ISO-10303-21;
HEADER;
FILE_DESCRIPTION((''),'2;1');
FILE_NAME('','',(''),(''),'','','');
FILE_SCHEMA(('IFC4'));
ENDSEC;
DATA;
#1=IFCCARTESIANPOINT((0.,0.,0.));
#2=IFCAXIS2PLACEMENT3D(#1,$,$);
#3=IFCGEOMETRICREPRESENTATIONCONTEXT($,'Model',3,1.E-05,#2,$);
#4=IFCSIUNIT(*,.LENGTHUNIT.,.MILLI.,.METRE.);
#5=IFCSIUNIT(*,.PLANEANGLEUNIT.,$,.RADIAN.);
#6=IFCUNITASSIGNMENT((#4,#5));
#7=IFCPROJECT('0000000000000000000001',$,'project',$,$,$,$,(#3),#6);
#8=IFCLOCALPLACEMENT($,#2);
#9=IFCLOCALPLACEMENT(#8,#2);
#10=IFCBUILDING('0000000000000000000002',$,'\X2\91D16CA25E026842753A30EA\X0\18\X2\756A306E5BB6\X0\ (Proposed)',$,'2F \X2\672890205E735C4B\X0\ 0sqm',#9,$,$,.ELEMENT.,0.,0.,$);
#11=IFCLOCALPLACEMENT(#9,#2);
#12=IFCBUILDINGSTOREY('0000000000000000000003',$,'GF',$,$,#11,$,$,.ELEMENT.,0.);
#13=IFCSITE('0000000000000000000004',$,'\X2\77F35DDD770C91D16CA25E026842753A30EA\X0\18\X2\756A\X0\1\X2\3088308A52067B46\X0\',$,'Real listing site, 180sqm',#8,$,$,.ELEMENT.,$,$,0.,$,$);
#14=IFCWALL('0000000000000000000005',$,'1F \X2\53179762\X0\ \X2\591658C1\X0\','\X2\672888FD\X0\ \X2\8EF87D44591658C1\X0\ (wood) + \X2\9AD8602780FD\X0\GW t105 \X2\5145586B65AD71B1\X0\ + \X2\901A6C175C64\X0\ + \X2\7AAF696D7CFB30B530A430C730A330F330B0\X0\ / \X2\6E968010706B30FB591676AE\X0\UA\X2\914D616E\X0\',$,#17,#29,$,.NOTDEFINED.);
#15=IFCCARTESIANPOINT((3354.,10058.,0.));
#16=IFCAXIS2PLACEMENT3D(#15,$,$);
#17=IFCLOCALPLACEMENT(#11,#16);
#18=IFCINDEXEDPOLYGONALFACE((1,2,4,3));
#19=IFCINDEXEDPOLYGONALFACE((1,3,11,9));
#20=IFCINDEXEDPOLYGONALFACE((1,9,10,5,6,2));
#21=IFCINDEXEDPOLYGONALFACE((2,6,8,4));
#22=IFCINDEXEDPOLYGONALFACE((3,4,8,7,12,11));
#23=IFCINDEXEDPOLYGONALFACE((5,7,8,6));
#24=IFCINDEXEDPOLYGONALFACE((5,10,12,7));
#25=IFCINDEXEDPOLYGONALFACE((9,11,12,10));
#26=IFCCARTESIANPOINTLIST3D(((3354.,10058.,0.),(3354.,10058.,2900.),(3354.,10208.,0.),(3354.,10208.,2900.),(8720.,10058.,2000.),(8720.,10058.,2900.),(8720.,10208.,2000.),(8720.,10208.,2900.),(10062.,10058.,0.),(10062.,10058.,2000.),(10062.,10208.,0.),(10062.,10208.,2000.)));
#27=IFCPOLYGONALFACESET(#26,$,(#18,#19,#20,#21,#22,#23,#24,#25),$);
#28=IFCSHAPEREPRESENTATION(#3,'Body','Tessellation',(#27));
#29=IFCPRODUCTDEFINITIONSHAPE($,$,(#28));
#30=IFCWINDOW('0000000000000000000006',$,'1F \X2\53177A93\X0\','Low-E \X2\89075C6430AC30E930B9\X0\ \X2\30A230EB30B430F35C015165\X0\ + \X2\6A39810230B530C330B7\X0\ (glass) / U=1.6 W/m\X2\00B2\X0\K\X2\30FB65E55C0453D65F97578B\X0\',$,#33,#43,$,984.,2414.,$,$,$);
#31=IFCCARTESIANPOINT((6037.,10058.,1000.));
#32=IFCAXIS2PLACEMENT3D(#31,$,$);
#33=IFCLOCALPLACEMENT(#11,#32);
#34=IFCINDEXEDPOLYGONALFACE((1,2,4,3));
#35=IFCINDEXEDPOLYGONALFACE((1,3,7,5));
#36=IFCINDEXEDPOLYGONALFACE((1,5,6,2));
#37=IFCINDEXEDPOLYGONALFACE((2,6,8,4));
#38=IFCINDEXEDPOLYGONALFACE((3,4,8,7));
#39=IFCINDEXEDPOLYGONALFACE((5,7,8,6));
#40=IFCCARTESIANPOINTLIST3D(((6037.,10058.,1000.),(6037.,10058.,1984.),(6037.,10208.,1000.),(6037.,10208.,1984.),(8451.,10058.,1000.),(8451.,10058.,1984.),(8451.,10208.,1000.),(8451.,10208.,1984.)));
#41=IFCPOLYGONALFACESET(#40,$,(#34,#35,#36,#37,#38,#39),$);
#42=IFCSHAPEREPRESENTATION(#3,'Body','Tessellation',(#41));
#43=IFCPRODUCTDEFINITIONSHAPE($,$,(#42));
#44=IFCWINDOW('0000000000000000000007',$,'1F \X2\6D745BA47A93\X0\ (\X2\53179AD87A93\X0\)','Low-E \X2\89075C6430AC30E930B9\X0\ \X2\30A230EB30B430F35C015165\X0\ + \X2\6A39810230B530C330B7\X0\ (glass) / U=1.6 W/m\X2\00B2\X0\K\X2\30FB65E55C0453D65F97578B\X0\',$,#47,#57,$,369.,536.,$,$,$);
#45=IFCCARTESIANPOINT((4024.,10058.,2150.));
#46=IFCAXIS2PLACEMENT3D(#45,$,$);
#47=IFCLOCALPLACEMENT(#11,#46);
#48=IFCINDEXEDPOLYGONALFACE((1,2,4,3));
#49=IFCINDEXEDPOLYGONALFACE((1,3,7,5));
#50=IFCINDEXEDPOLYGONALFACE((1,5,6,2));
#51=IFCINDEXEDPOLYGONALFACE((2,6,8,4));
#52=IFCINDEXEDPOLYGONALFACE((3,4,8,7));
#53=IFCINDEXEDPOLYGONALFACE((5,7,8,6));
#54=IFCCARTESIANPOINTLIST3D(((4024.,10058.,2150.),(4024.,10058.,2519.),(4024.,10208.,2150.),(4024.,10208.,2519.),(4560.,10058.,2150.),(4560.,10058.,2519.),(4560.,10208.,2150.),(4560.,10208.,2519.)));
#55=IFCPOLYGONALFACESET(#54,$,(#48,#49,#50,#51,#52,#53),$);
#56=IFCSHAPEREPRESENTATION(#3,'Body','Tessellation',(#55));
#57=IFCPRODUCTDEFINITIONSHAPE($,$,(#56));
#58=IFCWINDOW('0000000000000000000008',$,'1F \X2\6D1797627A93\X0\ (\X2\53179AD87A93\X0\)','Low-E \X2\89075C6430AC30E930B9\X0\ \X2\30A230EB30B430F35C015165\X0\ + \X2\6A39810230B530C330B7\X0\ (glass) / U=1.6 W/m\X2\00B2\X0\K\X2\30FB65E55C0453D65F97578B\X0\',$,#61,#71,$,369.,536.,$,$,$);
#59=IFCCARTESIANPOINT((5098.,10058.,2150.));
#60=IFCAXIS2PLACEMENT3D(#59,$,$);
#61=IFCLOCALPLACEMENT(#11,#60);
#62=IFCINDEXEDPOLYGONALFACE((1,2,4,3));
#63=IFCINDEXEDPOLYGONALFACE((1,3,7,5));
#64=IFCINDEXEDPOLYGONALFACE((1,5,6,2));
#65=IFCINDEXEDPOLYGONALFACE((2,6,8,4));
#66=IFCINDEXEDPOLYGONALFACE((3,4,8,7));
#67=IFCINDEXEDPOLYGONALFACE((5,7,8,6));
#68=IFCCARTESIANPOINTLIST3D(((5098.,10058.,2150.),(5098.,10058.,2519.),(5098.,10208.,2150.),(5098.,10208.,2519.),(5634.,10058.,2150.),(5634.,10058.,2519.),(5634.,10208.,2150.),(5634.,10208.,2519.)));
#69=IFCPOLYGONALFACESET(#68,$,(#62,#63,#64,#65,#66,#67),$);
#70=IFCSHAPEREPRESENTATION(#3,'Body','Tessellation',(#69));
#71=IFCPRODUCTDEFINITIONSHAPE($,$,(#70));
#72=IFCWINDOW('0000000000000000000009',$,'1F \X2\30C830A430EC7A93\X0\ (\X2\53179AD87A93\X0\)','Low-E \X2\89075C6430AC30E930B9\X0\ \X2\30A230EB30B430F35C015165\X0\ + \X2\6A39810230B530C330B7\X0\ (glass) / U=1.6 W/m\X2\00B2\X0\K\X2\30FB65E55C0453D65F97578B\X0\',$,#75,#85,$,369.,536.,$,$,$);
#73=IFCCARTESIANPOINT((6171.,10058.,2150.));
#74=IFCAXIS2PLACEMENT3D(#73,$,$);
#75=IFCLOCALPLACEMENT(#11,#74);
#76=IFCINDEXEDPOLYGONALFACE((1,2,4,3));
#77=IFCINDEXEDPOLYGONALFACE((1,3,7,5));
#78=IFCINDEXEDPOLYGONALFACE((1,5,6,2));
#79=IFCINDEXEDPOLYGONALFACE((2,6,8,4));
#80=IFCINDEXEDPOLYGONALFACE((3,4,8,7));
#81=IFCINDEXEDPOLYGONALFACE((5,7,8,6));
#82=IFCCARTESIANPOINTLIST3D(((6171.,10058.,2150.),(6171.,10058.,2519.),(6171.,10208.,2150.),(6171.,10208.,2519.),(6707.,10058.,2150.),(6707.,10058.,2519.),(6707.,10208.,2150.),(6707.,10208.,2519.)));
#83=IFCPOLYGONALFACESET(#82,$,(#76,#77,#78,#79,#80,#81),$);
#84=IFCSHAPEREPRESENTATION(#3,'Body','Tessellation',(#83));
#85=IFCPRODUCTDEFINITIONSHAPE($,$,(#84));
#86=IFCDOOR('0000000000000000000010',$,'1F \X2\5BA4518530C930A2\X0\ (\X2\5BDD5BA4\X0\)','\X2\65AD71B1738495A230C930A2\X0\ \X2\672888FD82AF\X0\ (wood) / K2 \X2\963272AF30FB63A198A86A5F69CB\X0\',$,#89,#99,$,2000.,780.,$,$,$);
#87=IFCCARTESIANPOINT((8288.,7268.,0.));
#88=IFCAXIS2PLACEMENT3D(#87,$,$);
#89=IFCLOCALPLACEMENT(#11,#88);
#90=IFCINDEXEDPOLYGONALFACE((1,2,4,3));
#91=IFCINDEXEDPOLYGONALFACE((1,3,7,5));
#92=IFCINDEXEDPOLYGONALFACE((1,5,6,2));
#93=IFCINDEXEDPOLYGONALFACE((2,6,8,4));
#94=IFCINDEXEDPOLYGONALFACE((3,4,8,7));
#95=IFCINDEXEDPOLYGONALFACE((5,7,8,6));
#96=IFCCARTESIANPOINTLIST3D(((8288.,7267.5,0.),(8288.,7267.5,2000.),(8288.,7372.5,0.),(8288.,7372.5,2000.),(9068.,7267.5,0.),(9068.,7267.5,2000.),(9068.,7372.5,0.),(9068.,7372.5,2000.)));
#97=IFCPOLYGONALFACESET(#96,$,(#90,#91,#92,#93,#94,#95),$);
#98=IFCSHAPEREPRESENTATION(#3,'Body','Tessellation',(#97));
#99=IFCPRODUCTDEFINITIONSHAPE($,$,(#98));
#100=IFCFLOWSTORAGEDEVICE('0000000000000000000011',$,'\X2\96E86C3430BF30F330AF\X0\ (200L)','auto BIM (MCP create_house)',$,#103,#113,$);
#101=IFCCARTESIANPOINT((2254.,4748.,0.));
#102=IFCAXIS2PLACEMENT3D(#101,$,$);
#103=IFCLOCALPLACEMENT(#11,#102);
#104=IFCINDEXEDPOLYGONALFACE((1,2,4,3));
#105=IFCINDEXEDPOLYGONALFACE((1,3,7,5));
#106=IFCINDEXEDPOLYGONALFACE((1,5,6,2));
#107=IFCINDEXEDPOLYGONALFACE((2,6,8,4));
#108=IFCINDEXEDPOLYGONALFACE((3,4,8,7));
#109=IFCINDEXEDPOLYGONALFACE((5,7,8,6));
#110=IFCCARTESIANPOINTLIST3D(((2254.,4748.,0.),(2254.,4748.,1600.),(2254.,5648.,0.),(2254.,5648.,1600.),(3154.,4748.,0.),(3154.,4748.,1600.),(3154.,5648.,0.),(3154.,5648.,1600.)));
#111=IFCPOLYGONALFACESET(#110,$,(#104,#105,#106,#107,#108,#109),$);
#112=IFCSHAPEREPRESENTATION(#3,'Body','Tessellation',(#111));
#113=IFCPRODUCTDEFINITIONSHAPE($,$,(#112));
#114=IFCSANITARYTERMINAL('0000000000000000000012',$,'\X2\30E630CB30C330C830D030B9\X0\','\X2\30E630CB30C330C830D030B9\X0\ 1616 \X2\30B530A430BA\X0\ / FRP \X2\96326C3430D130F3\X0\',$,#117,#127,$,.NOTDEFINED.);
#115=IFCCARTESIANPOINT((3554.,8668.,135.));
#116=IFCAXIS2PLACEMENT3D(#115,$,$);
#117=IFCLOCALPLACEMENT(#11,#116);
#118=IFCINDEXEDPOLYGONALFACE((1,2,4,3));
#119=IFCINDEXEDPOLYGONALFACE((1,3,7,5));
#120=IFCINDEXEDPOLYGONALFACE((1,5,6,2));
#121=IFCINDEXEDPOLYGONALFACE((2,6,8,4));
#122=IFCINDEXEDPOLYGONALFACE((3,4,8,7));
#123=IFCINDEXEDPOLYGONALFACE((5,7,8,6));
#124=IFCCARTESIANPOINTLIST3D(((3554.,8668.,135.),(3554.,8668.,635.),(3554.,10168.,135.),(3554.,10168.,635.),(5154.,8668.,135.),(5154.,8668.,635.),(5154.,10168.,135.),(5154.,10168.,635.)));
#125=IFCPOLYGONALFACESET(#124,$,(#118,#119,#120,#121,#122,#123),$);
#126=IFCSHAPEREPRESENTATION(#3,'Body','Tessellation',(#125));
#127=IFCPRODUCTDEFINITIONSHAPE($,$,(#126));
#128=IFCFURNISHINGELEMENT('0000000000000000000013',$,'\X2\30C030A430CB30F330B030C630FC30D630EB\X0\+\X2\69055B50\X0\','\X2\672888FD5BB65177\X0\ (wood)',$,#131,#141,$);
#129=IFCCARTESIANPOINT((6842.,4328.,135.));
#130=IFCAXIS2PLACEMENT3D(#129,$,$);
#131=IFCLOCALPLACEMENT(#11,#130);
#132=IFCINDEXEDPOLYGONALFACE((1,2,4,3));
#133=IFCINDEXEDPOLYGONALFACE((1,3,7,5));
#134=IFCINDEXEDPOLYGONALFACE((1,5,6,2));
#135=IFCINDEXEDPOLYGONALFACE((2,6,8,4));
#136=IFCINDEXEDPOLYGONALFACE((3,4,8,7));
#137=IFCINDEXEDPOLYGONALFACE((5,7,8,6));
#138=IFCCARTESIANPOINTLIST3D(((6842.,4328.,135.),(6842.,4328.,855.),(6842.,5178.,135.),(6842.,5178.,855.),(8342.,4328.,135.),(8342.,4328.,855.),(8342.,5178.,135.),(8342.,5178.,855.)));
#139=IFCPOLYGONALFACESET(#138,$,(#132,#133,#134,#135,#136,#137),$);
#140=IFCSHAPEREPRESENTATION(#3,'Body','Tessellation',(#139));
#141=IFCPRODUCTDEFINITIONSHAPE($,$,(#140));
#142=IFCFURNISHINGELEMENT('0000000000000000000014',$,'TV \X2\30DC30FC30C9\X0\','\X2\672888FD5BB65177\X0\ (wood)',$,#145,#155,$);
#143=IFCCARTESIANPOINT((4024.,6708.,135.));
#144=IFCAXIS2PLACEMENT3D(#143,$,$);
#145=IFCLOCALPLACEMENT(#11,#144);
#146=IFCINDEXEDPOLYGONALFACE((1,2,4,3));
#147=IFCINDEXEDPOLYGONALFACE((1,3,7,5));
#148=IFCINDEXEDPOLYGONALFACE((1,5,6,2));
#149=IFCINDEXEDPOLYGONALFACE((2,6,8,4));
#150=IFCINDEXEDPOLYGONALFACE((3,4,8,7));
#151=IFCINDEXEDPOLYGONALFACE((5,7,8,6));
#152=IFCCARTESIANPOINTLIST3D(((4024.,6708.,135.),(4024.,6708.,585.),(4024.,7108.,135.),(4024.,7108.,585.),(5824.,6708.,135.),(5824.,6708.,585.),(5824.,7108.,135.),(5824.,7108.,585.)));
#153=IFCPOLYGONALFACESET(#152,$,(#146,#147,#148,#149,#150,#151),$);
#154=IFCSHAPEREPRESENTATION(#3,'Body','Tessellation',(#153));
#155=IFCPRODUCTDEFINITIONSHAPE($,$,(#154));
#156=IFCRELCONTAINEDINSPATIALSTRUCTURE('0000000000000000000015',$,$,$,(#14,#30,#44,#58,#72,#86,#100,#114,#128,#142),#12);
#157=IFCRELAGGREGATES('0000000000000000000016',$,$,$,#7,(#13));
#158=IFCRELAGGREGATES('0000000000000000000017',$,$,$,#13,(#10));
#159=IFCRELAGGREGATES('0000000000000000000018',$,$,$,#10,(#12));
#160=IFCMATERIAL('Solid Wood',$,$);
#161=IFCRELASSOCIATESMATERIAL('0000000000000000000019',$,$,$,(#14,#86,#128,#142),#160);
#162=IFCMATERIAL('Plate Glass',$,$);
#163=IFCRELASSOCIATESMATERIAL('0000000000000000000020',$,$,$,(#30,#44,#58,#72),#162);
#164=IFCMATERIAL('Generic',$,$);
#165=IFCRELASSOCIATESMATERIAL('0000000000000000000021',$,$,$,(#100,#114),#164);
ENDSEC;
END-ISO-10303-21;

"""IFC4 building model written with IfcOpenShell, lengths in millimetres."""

from ifc_helpers import new_model, si_unit, frame, frame_2d, origin, place, context, project, spatial, rectangle, extrude, material, element, fill, save


model = new_model("IFC4")

# Units and contexts
model_context = context("Model", 3, precision=1e-05, world=origin())
ifc_project = project(units=[si_unit("LENGTHUNIT", "METRE", prefix="MILLI"), si_unit("PLANEANGLEUNIT", "RADIAN")], contexts=[model_context])

# Site, building, storey
site_placement = place(None, origin())
site = spatial("IfcSite", under=ifc_project, at=site_placement, Name="石川県金沢市桂町リ18番1より分筆", ObjectType="Real listing site, 180sqm", CompositionType="ELEMENT", RefElevation=0.0)
building_placement = place(site_placement, origin())
building = spatial("IfcBuilding", under=site, at=building_placement, Name="金沢市桂町リ18番の家 (Proposed)", ObjectType="2F 木造平屋 0sqm", CompositionType="ELEMENT", ElevationOfRefHeight=0.0, ElevationOfTerrain=0.0)
storey_placement = place(building_placement, origin())
storey = spatial("IfcBuildingStorey", under=building, at=storey_placement, Name="GF", CompositionType="ELEMENT", Elevation=0.0)

# Wall, openings, windows
ifc_material_1 = material(Name="Solid Wood")
wall_1_placement = place(storey_placement, frame((3354.0, 10058.0, 0.0)))
wall_1 = element("IfcWall", 1, at=wall_1_placement, inside=storey, material=ifc_material_1, Name="1F 北面 外壁", Description="木製 軸組外壁 (wood) + 高性能GW t105 充填断熱 + 通気層 + 窯業系サイディング / 準耐火・外皮UA配慮", PredefinedType="NOTDEFINED", context=model_context, shape_type="SweptSolid", body=[
    extrude(rectangle(XDim=6708.0, YDim=150.0, at=frame_2d((3354.0, 75.0))), frame((3354.0, 10058.0, 0.0)), (0.0, 0.0, 1.0), 2900.0),
])
opening_1_placement = place(storey_placement, frame((6037.0, 10058.0, 1000.0)))
opening_1 = element("IfcOpeningElement", 2, at=opening_1_placement, cuts=wall_1, PredefinedType="NOTDEFINED", context=model_context, shape_type="SweptSolid", body=[
    extrude(rectangle(XDim=2414.0, YDim=150.0, at=frame_2d((1207.0, 75.0))), frame((6037.0, 10058.0, 1000.0)), (0.0, 0.0, 1.0), 984.0),
])
opening_2_placement = place(storey_placement, frame((4024.0, 10058.0, 2150.0)))
opening_2 = element("IfcOpeningElement", 3, at=opening_2_placement, cuts=wall_1, PredefinedType="NOTDEFINED", context=model_context, shape_type="SweptSolid", body=[
    extrude(rectangle(XDim=536.0, YDim=150.0, at=frame_2d((268.0, 75.0))), frame((4024.0, 10058.0, 2150.0)), (0.0, 0.0, 1.0), 369.0),
])
opening_3_placement = place(storey_placement, frame((5098.0, 10058.0, 2150.0)))
opening_3 = element("IfcOpeningElement", 4, at=opening_3_placement, cuts=wall_1, PredefinedType="NOTDEFINED", context=model_context, shape_type="SweptSolid", body=[
    extrude(rectangle(XDim=536.0, YDim=150.0, at=frame_2d((268.0, 75.0))), frame((5098.0, 10058.0, 2150.0)), (0.0, 0.0, 1.0), 369.0),
])
opening_4_placement = place(storey_placement, frame((6171.0, 10058.0, 2150.0)))
opening_4 = element("IfcOpeningElement", 5, at=opening_4_placement, cuts=wall_1, PredefinedType="NOTDEFINED", context=model_context, shape_type="SweptSolid", body=[
    extrude(rectangle(XDim=536.0, YDim=150.0, at=frame_2d((268.0, 75.0))), frame((6171.0, 10058.0, 2150.0)), (0.0, 0.0, 1.0), 369.0),
])
ifc_material_2 = material(Name="Plate Glass")
window_1_placement = place(storey_placement, frame((6037.0, 10058.0, 1000.0)))
window_1 = element("IfcWindow", 6, at=window_1_placement, inside=storey, material=ifc_material_2, Name="1F 北窓", Description="Low-E 複層ガラス アルゴン封入 + 樹脂サッシ (glass) / U=1.6 W/m²K・日射取得型", OverallHeight=984.0, OverallWidth=2414.0, context=model_context, shape_type="SweptSolid", body=[
    extrude(rectangle(XDim=2414.0, YDim=150.0, at=frame_2d((1207.0, 75.0))), frame((6037.0, 10058.0, 1000.0)), (0.0, 0.0, 1.0), 984.0),
])
fill(opening_1, window_1)
window_2_placement = place(storey_placement, frame((4024.0, 10058.0, 2150.0)))
window_2 = element("IfcWindow", 7, at=window_2_placement, inside=storey, material=ifc_material_2, Name="1F 浴室窓 (北高窓)", Description="Low-E 複層ガラス アルゴン封入 + 樹脂サッシ (glass) / U=1.6 W/m²K・日射取得型", OverallHeight=369.0, OverallWidth=536.0, context=model_context, shape_type="SweptSolid", body=[
    extrude(rectangle(XDim=536.0, YDim=150.0, at=frame_2d((268.0, 75.0))), frame((4024.0, 10058.0, 2150.0)), (0.0, 0.0, 1.0), 369.0),
])
fill(opening_2, window_2)
window_3_placement = place(storey_placement, frame((5098.0, 10058.0, 2150.0)))
window_3 = element("IfcWindow", 8, at=window_3_placement, inside=storey, material=ifc_material_2, Name="1F 洗面窓 (北高窓)", Description="Low-E 複層ガラス アルゴン封入 + 樹脂サッシ (glass) / U=1.6 W/m²K・日射取得型", OverallHeight=369.0, OverallWidth=536.0, context=model_context, shape_type="SweptSolid", body=[
    extrude(rectangle(XDim=536.0, YDim=150.0, at=frame_2d((268.0, 75.0))), frame((5098.0, 10058.0, 2150.0)), (0.0, 0.0, 1.0), 369.0),
])
fill(opening_3, window_3)
window_4_placement = place(storey_placement, frame((6171.0, 10058.0, 2150.0)))
window_4 = element("IfcWindow", 9, at=window_4_placement, inside=storey, material=ifc_material_2, Name="1F トイレ窓 (北高窓)", Description="Low-E 複層ガラス アルゴン封入 + 樹脂サッシ (glass) / U=1.6 W/m²K・日射取得型", OverallHeight=369.0, OverallWidth=536.0, context=model_context, shape_type="SweptSolid", body=[
    extrude(rectangle(XDim=536.0, YDim=150.0, at=frame_2d((268.0, 75.0))), frame((6171.0, 10058.0, 2150.0)), (0.0, 0.0, 1.0), 369.0),
])
fill(opening_4, window_4)

# Door
door_1_placement = place(storey_placement, frame((8288.0, 7268.0, 0.0)))
element("IfcDoor", 10, at=door_1_placement, inside=storey, material=ifc_material_1, Name="1F 室内ドア (寝室)", Description="断熱玄関ドア 木製芯 (wood) / K2 防犯・採風機構", OverallHeight=2000.0, OverallWidth=780.0, context=model_context, shape_type="SweptSolid", body=[
    extrude(rectangle(XDim=780.0, YDim=105.0, at=frame_2d((390.0, 52.0))), frame((8288.0, 7268.0, 0.0)), (0.0, 0.0, 1.0), 2000.0),
])

# Flow storage device
ifc_material_3 = material(Name="Generic")
flow_storage_device_placement = place(storey_placement, frame((2254.0, 4748.0, 0.0)))
element("IfcFlowStorageDevice", 11, at=flow_storage_device_placement, inside=storey, material=ifc_material_3, Name="雨水タンク (200L)", Description="auto BIM (MCP create_house)", context=model_context, shape_type="SweptSolid", body=[
    extrude(rectangle(XDim=900.0, YDim=900.0, at=frame_2d((450.0, 450.0))), frame((2254.0, 4748.0, 0.0)), (0.0, 0.0, 1.0), 1600.0),
])

# Sanitary terminal
sanitary_terminal_placement = place(storey_placement, frame((3554.0, 8668.0, 135.0)))
element("IfcSanitaryTerminal", 12, at=sanitary_terminal_placement, inside=storey, material=ifc_material_3, Name="ユニットバス", Description="ユニットバス 1616 サイズ / FRP 防水パン", PredefinedType="NOTDEFINED", context=model_context, shape_type="SweptSolid", body=[
    extrude(rectangle(XDim=1600.0, YDim=1500.0, at=frame_2d((800.0, 750.0))), frame((3554.0, 8668.0, 135.0)), (0.0, 0.0, 1.0), 500.0),
])

# Furnishing elements
furnishing_1_placement = place(storey_placement, frame((6842.0, 4328.0, 135.0)))
element("IfcFurnishingElement", 13, at=furnishing_1_placement, inside=storey, material=ifc_material_1, Name="ダイニングテーブル+椅子", Description="木製家具 (wood)", context=model_context, shape_type="SweptSolid", body=[
    extrude(rectangle(XDim=1500.0, YDim=850.0, at=frame_2d((750.0, 425.0))), frame((6842.0, 4328.0, 135.0)), (0.0, 0.0, 1.0), 720.0),
])
furnishing_2_placement = place(storey_placement, frame((4024.0, 6708.0, 135.0)))
element("IfcFurnishingElement", 14, at=furnishing_2_placement, inside=storey, material=ifc_material_1, Name="TV ボード", Description="木製家具 (wood)", context=model_context, shape_type="SweptSolid", body=[
    extrude(rectangle(XDim=1800.0, YDim=400.0, at=frame_2d((900.0, 200.0))), frame((4024.0, 6708.0, 135.0)), (0.0, 0.0, 1.0), 450.0),
])

save(model, "model.ifc")
